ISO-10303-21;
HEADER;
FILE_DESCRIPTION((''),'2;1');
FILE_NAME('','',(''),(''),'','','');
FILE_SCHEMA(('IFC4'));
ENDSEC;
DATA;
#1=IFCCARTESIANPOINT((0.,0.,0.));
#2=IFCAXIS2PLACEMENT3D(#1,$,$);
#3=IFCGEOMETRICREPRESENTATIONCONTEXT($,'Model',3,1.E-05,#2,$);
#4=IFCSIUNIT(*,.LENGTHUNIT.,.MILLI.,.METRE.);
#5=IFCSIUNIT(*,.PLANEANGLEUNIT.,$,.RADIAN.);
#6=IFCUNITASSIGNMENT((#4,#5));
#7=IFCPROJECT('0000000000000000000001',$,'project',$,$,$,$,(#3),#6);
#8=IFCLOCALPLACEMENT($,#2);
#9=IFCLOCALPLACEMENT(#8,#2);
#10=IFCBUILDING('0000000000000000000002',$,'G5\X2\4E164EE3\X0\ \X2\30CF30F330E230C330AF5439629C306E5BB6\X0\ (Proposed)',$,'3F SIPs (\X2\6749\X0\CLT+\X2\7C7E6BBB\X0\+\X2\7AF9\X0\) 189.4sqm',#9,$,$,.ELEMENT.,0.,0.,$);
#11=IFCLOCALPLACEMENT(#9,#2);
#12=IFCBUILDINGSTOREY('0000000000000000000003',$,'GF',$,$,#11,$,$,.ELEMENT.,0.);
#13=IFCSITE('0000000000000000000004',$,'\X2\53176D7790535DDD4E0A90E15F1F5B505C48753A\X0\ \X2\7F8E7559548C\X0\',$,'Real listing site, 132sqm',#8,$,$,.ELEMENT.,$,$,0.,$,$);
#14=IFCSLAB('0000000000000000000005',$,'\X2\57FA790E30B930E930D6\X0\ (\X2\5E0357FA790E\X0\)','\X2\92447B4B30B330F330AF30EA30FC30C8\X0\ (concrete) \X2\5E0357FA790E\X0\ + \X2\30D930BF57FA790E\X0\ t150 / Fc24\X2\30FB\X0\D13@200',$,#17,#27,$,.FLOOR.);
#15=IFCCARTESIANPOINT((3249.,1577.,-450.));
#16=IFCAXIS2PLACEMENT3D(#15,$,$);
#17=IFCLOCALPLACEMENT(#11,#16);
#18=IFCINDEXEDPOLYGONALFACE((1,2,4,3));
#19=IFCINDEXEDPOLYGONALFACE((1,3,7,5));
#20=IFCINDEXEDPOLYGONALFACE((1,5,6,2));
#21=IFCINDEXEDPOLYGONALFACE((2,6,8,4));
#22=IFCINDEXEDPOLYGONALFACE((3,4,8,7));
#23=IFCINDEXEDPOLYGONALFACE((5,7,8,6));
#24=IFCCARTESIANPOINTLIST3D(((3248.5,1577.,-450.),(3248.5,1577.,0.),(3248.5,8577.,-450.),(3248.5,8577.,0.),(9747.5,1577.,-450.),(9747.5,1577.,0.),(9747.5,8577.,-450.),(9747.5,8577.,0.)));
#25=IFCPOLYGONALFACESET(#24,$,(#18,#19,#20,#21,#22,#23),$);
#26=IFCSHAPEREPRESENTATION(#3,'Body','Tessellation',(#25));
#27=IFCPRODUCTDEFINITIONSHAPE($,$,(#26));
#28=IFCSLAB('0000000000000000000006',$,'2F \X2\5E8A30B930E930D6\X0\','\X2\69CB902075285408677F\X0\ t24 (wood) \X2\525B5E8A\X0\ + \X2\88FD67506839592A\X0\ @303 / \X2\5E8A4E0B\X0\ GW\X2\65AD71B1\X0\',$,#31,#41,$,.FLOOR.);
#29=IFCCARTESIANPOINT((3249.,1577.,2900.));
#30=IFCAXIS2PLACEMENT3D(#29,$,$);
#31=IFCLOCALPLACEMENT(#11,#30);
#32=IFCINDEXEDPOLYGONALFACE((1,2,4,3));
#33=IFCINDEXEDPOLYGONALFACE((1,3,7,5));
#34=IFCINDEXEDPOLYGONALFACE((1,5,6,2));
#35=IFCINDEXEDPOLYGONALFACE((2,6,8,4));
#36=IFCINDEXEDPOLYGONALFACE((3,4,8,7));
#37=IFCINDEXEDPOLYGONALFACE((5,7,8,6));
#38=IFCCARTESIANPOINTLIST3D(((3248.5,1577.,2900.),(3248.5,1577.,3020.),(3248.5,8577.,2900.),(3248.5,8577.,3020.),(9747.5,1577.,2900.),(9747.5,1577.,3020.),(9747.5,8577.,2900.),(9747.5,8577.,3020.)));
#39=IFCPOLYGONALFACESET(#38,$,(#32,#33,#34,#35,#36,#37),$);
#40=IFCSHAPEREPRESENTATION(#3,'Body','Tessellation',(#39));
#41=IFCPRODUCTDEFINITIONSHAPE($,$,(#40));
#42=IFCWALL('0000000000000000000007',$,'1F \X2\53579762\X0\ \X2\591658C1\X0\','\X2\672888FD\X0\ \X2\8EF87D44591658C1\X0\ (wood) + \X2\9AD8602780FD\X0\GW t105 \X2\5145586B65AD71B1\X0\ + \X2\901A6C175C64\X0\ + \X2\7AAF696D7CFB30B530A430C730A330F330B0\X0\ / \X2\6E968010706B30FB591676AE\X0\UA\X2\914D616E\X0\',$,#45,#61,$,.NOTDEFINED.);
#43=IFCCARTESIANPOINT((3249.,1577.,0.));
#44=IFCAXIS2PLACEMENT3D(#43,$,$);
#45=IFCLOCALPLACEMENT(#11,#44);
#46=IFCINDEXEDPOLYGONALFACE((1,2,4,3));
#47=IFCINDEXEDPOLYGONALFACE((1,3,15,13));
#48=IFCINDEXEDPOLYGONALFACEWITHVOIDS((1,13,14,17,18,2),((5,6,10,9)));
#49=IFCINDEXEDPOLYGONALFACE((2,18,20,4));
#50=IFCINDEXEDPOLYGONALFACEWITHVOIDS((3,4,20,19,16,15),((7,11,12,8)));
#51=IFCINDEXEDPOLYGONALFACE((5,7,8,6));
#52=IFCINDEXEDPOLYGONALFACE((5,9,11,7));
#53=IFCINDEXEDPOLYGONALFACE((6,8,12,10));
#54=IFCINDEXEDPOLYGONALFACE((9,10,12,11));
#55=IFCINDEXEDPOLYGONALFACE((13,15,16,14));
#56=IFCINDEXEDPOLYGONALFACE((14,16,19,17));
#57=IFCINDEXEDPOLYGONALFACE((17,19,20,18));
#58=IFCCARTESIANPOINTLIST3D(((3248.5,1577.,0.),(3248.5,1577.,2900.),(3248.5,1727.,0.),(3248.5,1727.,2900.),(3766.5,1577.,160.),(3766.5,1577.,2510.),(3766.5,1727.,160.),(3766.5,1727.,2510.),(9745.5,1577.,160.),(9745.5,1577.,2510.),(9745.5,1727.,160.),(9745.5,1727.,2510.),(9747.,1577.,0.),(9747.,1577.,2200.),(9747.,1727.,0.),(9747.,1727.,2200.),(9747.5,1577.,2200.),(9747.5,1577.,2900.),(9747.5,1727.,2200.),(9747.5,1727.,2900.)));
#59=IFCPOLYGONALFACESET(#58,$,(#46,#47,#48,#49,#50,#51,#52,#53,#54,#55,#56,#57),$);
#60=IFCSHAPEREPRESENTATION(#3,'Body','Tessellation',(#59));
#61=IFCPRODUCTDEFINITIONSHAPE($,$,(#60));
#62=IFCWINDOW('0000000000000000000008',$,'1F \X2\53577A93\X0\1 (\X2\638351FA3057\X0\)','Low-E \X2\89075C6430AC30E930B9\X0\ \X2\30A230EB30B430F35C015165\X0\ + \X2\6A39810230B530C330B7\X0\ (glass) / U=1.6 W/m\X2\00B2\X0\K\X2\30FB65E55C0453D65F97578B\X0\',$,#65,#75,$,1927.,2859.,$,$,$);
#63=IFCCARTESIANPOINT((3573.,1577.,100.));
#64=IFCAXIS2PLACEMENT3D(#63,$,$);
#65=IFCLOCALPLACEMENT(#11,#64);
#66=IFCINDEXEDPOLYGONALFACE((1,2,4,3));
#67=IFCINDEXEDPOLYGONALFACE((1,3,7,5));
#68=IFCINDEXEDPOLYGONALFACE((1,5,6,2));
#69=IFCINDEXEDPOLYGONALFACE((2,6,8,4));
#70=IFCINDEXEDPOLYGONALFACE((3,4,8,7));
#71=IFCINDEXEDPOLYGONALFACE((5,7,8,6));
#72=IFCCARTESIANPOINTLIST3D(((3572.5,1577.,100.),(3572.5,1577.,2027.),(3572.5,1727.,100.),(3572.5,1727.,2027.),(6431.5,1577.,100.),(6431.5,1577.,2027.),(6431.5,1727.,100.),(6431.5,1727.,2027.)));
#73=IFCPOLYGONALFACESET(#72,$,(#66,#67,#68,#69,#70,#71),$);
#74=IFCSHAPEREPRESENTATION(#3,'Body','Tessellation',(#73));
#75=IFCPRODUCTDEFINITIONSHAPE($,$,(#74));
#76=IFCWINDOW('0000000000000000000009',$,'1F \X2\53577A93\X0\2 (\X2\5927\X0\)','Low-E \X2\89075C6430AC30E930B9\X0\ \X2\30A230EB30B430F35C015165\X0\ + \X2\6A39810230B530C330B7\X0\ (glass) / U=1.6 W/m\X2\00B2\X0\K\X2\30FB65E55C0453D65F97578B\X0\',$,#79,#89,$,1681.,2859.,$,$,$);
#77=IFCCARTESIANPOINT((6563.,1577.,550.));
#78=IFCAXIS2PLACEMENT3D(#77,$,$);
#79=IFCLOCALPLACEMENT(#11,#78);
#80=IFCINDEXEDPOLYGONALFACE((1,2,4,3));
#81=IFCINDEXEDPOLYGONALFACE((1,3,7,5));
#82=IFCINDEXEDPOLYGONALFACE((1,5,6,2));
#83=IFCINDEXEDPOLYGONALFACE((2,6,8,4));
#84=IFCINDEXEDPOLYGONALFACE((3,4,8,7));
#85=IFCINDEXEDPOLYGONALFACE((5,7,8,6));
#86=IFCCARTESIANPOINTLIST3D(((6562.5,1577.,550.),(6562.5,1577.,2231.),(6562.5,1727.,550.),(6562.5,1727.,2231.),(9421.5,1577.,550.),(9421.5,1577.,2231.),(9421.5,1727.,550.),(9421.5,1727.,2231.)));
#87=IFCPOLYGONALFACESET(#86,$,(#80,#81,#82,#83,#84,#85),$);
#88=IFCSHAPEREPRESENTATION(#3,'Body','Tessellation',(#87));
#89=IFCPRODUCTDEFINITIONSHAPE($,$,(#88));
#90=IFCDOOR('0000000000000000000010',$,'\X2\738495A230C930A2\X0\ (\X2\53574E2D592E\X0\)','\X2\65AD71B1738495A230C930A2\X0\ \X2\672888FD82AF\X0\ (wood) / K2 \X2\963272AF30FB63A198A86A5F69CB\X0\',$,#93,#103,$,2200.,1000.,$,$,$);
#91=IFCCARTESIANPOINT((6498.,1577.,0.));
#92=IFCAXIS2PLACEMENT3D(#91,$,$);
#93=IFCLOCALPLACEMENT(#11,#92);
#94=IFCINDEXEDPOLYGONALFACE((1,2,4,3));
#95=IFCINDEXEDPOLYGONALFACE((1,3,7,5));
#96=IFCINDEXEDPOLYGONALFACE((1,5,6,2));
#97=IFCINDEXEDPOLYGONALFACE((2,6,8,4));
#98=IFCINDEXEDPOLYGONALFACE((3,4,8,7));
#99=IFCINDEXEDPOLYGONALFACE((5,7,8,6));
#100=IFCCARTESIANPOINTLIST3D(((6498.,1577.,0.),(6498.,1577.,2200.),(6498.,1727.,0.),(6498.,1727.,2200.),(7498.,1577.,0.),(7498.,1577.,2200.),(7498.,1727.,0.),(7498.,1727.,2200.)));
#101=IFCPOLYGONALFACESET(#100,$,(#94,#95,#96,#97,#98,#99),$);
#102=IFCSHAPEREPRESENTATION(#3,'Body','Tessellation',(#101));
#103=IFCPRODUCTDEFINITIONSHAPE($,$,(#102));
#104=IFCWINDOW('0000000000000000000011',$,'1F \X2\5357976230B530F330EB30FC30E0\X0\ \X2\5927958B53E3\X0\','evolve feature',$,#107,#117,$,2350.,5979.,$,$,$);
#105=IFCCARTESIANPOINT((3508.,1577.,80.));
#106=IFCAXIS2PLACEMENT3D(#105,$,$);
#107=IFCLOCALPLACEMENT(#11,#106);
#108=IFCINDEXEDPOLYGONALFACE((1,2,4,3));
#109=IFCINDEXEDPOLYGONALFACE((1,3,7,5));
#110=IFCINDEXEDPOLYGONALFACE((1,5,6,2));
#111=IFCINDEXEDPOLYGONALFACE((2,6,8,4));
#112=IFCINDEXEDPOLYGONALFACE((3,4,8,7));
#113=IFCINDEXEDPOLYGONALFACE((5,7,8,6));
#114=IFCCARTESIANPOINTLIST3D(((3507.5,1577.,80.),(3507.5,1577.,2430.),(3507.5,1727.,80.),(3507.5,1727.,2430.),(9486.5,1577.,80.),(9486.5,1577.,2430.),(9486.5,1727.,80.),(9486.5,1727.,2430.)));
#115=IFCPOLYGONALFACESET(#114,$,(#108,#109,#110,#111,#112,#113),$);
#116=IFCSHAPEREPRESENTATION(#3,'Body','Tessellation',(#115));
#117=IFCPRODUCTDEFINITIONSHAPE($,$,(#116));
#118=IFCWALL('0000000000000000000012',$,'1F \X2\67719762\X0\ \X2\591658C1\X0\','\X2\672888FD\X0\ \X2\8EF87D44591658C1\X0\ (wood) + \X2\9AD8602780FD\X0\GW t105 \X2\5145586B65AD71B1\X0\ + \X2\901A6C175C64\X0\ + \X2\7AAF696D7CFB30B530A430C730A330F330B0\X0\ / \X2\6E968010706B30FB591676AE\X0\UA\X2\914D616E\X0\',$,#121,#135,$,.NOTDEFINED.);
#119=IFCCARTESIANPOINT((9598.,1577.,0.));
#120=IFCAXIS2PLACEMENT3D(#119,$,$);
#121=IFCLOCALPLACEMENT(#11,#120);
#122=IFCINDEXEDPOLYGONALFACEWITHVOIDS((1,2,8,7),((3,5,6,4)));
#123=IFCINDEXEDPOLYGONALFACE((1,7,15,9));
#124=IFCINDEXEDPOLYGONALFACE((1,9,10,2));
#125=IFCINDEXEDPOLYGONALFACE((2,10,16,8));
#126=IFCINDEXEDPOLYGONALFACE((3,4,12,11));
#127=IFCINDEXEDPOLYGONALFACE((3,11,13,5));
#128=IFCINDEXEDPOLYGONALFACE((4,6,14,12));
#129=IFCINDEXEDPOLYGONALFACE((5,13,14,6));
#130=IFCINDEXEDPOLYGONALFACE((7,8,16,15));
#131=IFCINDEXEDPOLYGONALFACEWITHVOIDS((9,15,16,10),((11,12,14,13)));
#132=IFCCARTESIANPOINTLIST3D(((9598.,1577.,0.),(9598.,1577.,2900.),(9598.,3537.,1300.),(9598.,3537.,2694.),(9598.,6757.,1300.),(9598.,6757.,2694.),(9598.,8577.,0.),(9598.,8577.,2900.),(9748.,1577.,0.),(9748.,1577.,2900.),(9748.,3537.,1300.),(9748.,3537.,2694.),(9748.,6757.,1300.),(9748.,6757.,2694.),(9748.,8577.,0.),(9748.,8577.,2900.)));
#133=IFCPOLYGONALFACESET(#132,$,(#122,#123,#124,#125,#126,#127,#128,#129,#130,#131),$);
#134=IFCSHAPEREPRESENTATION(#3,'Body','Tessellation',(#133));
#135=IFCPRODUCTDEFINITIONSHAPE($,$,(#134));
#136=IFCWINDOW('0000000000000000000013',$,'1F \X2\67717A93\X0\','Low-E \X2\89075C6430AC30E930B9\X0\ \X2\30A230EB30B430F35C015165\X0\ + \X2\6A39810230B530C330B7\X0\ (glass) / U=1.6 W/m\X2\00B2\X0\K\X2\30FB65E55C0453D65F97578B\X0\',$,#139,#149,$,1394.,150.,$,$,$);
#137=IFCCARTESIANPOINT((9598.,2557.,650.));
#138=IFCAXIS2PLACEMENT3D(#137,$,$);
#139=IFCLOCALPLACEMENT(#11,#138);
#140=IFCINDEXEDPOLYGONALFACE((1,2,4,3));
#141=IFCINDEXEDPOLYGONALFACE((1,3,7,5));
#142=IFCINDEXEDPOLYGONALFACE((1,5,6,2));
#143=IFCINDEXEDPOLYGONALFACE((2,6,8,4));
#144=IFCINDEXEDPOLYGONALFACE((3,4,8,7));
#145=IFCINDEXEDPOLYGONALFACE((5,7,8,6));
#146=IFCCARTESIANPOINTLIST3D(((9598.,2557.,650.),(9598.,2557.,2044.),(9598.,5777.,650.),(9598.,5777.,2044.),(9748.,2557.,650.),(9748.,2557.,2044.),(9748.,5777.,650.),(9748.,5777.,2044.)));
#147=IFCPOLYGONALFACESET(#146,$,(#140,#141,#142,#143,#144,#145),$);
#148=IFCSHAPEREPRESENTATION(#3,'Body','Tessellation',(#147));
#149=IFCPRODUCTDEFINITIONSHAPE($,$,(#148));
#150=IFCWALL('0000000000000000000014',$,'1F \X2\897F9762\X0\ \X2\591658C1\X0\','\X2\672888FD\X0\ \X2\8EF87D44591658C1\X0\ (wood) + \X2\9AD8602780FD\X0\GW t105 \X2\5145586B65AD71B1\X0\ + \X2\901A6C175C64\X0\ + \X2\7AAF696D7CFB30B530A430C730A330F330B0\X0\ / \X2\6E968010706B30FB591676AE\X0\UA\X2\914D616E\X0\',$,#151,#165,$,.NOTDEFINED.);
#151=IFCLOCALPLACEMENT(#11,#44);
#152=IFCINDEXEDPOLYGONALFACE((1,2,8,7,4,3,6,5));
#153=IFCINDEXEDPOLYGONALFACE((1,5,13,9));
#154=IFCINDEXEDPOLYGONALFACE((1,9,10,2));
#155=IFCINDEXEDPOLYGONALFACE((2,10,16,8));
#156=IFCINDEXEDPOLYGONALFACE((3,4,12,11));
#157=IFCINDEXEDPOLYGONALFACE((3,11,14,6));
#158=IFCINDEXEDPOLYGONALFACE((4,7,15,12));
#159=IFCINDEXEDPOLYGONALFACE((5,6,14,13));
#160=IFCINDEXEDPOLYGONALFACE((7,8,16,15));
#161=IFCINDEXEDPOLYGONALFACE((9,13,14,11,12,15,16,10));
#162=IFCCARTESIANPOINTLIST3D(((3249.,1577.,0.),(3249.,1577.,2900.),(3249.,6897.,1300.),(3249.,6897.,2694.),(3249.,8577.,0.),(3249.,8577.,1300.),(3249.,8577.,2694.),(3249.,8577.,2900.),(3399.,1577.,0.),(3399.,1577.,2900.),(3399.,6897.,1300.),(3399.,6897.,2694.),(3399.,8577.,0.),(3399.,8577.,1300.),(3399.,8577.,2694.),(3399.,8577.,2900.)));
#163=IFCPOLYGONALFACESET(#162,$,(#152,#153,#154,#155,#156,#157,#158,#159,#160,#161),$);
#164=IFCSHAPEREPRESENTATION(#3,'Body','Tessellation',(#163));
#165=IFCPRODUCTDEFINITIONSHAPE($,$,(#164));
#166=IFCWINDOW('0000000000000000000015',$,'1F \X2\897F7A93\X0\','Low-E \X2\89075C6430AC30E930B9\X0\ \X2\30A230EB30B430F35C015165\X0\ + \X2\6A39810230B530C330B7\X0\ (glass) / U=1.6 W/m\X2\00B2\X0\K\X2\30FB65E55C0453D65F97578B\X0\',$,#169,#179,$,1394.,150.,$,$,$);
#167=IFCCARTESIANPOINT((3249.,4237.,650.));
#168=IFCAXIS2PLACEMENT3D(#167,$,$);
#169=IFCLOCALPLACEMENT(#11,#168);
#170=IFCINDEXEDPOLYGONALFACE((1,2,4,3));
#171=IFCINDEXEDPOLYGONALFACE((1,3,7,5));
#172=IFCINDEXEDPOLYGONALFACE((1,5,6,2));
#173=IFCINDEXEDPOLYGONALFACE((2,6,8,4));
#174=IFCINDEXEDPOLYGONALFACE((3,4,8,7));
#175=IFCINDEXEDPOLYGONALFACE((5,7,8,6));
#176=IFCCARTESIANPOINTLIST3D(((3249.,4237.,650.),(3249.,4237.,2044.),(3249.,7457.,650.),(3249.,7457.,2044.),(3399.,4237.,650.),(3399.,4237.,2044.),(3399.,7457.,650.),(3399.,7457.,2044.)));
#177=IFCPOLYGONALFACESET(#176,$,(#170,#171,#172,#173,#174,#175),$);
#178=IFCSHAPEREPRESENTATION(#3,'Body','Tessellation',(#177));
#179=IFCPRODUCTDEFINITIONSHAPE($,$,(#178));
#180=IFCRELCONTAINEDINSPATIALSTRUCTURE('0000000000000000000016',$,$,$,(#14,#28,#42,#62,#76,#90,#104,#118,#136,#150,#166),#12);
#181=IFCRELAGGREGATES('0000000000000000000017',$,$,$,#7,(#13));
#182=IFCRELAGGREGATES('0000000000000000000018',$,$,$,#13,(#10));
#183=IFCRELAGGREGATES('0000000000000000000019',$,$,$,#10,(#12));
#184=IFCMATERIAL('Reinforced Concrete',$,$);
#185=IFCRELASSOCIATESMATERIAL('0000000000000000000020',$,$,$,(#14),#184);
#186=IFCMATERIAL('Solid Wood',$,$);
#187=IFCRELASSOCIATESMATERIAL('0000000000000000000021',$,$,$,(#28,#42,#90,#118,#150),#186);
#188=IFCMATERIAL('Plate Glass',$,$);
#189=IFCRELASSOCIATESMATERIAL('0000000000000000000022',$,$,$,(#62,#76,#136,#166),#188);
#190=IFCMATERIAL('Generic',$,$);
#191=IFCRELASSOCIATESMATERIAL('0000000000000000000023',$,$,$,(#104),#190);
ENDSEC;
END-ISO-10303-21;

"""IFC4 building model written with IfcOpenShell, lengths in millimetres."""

from ifc_helpers import new_model, si_unit, frame, frame_2d, origin, place, context, project, spatial, rectangle, extrude, material, element, fill, save


model = new_model("IFC4")

# Units and contexts
model_context = context("Model", 3, precision=1e-05, world=origin())
ifc_project = project(units=[si_unit("LENGTHUNIT", "METRE", prefix="MILLI"), si_unit("PLANEANGLEUNIT", "RADIAN")], contexts=[model_context])

# Site, building, storey
site_placement = place(None, origin())
site = spatial("IfcSite", under=ifc_project, at=site_placement, Name="北海道川上郡弟子屈町 美留和", ObjectType="Real listing site, 132sqm", CompositionType="ELEMENT", RefElevation=0.0)
building_placement = place(site_placement, origin())
building = spatial("IfcBuilding", under=site, at=building_placement, Name="G5世代 ハンモック吹抜の家 (Proposed)", ObjectType="3F SIPs (杉CLT+籾殻+竹) 189.4sqm", CompositionType="ELEMENT", ElevationOfRefHeight=0.0, ElevationOfTerrain=0.0)
storey_placement = place(building_placement, origin())
storey = spatial("IfcBuildingStorey", under=building, at=storey_placement, Name="GF", CompositionType="ELEMENT", Elevation=0.0)

# Slabs
ifc_material_1 = material(Name="Reinforced Concrete")
slab_1_placement = place(storey_placement, frame((3249.0, 1577.0, -450.0)))
element("IfcSlab", 1, at=slab_1_placement, inside=storey, material=ifc_material_1, Name="基礎スラブ (布基礎)", Description="鉄筋コンクリート (concrete) 布基礎 + ベタ基礎 t150 / Fc24・D13@200", PredefinedType="FLOOR", context=model_context, shape_type="SweptSolid", body=[
    extrude(rectangle(XDim=6499.0, YDim=7000.0, at=frame_2d((3249.0, 3500.0))), frame((3249.0, 1577.0, -450.0)), (0.0, 0.0, 1.0), 450.0),
])
ifc_material_2 = material(Name="Solid Wood")
slab_2_placement = place(storey_placement, frame((3249.0, 1577.0, 2900.0)))
element("IfcSlab", 2, at=slab_2_placement, inside=storey, material=ifc_material_2, Name="2F 床スラブ", Description="構造用合板 t24 (wood) 剛床 + 製材根太 @303 / 床下 GW断熱", PredefinedType="FLOOR", context=model_context, shape_type="SweptSolid", body=[
    extrude(rectangle(XDim=6499.0, YDim=7000.0, at=frame_2d((3249.0, 3500.0))), frame((3249.0, 1577.0, 2900.0)), (0.0, 0.0, 1.0), 120.0),
])

# Wall, openings, windows, door
wall_1_placement = place(storey_placement, frame((3249.0, 1577.0, 0.0)))
wall_1 = element("IfcWall", 3, at=wall_1_placement, inside=storey, material=ifc_material_2, Name="1F 南面 外壁", Description="木製 軸組外壁 (wood) + 高性能GW t105 充填断熱 + 通気層 + 窯業系サイディング / 準耐火・外皮UA配慮", PredefinedType="NOTDEFINED", context=model_context, shape_type="SweptSolid", body=[
    extrude(rectangle(XDim=6499.0, YDim=150.0, at=frame_2d((3249.0, 75.0))), frame((3249.0, 1577.0, 0.0)), (0.0, 0.0, 1.0), 2900.0),
])
opening_1_placement = place(storey_placement, frame((3573.0, 1577.0, 100.0)))
opening_1 = element("IfcOpeningElement", 4, at=opening_1_placement, cuts=wall_1, PredefinedType="NOTDEFINED", context=model_context, shape_type="SweptSolid", body=[
    extrude(rectangle(XDim=2859.0, YDim=150.0, at=frame_2d((1429.0, 75.0))), frame((3573.0, 1577.0, 100.0)), (0.0, 0.0, 1.0), 1927.0),
])
opening_2_placement = place(storey_placement, frame((6563.0, 1577.0, 550.0)))
opening_2 = element("IfcOpeningElement", 5, at=opening_2_placement, cuts=wall_1, PredefinedType="NOTDEFINED", context=model_context, shape_type="SweptSolid", body=[
    extrude(rectangle(XDim=2859.0, YDim=150.0, at=frame_2d((1429.0, 75.0))), frame((6563.0, 1577.0, 550.0)), (0.0, 0.0, 1.0), 1681.0),
])
opening_3_placement = place(storey_placement, frame((6498.0, 1577.0, 0.0)))
opening_3 = element("IfcOpeningElement", 6, at=opening_3_placement, cuts=wall_1, PredefinedType="NOTDEFINED", context=model_context, shape_type="SweptSolid", body=[
    extrude(rectangle(XDim=1000.0, YDim=150.0, at=frame_2d((500.0, 75.0))), frame((6498.0, 1577.0, 0.0)), (0.0, 0.0, 1.0), 2200.0),
])
opening_4_placement = place(storey_placement, frame((3508.0, 1577.0, 80.0)))
opening_4 = element("IfcOpeningElement", 7, at=opening_4_placement, cuts=wall_1, PredefinedType="NOTDEFINED", context=model_context, shape_type="SweptSolid", body=[
    extrude(rectangle(XDim=5979.0, YDim=150.0, at=frame_2d((2989.0, 75.0))), frame((3508.0, 1577.0, 80.0)), (0.0, 0.0, 1.0), 2350.0),
])
ifc_material_3 = material(Name="Plate Glass")
window_1_placement = place(storey_placement, frame((3573.0, 1577.0, 100.0)))
window_1 = element("IfcWindow", 8, at=window_1_placement, inside=storey, material=ifc_material_3, Name="1F 南窓1 (掃出し)", Description="Low-E 複層ガラス アルゴン封入 + 樹脂サッシ (glass) / U=1.6 W/m²K・日射取得型", OverallHeight=1927.0, OverallWidth=2859.0, context=model_context, shape_type="SweptSolid", body=[
    extrude(rectangle(XDim=2859.0, YDim=150.0, at=frame_2d((1429.0, 75.0))), frame((3573.0, 1577.0, 100.0)), (0.0, 0.0, 1.0), 1927.0),
])
fill(opening_1, window_1)
window_2_placement = place(storey_placement, frame((6563.0, 1577.0, 550.0)))
window_2 = element("IfcWindow", 9, at=window_2_placement, inside=storey, material=ifc_material_3, Name="1F 南窓2 (大)", Description="Low-E 複層ガラス アルゴン封入 + 樹脂サッシ (glass) / U=1.6 W/m²K・日射取得型", OverallHeight=1681.0, OverallWidth=2859.0, context=model_context, shape_type="SweptSolid", body=[
    extrude(rectangle(XDim=2859.0, YDim=150.0, at=frame_2d((1429.0, 75.0))), frame((6563.0, 1577.0, 550.0)), (0.0, 0.0, 1.0), 1681.0),
])
fill(opening_2, window_2)
door_placement = place(storey_placement, frame((6498.0, 1577.0, 0.0)))
door = element("IfcDoor", 10, at=door_placement, inside=storey, material=ifc_material_2, Name="玄関ドア (南中央)", Description="断熱玄関ドア 木製芯 (wood) / K2 防犯・採風機構", OverallHeight=2200.0, OverallWidth=1000.0, context=model_context, shape_type="SweptSolid", body=[
    extrude(rectangle(XDim=1000.0, YDim=150.0, at=frame_2d((500.0, 75.0))), frame((6498.0, 1577.0, 0.0)), (0.0, 0.0, 1.0), 2200.0),
])
fill(opening_3, door)
ifc_material_4 = material(Name="Generic")
window_3_placement = place(storey_placement, frame((3508.0, 1577.0, 80.0)))
window_3 = element("IfcWindow", 11, at=window_3_placement, inside=storey, material=ifc_material_4, Name="1F 南面サンルーム 大開口", Description="evolve feature", OverallHeight=2350.0, OverallWidth=5979.0, context=model_context, shape_type="SweptSolid", body=[
    extrude(rectangle(XDim=5979.0, YDim=150.0, at=frame_2d((2989.0, 75.0))), frame((3508.0, 1577.0, 80.0)), (0.0, 0.0, 1.0), 2350.0),
])
fill(opening_4, window_3)

# Walls, openings, windows
wall_2_placement = place(storey_placement, frame((9598.0, 1577.0, 0.0)))
wall_2 = element("IfcWall", 12, at=wall_2_placement, inside=storey, material=ifc_material_2, Name="1F 東面 外壁", Description="木製 軸組外壁 (wood) + 高性能GW t105 充填断熱 + 通気層 + 窯業系サイディング / 準耐火・外皮UA配慮", PredefinedType="NOTDEFINED", context=model_context, shape_type="SweptSolid", body=[
    extrude(rectangle(XDim=150.0, YDim=7000.0, at=frame_2d((75.0, 3500.0))), frame((9598.0, 1577.0, 0.0)), (0.0, 0.0, 1.0), 2900.0),
])
opening_5_placement = place(storey_placement, frame((9598.0, 2557.0, 650.0)))
opening_5 = element("IfcOpeningElement", 13, at=opening_5_placement, cuts=wall_2, PredefinedType="NOTDEFINED", context=model_context, shape_type="SweptSolid", body=[
    extrude(rectangle(XDim=150.0, YDim=3220.0, at=frame_2d((75.0, 1610.0))), frame((9598.0, 2557.0, 650.0)), (0.0, 0.0, 1.0), 1394.0),
])
window_4_placement = place(storey_placement, frame((9598.0, 2557.0, 650.0)))
window_4 = element("IfcWindow", 14, at=window_4_placement, inside=storey, material=ifc_material_3, Name="1F 東窓", Description="Low-E 複層ガラス アルゴン封入 + 樹脂サッシ (glass) / U=1.6 W/m²K・日射取得型", OverallHeight=1394.0, OverallWidth=150.0, context=model_context, shape_type="SweptSolid", body=[
    extrude(rectangle(XDim=150.0, YDim=3220.0, at=frame_2d((75.0, 1610.0))), frame((9598.0, 2557.0, 650.0)), (0.0, 0.0, 1.0), 1394.0),
])
fill(opening_5, window_4)
wall_3_placement = place(storey_placement, frame((3249.0, 1577.0, 0.0)))
wall_3 = element("IfcWall", 15, at=wall_3_placement, inside=storey, material=ifc_material_2, Name="1F 西面 外壁", Description="木製 軸組外壁 (wood) + 高性能GW t105 充填断熱 + 通気層 + 窯業系サイディング / 準耐火・外皮UA配慮", PredefinedType="NOTDEFINED", context=model_context, shape_type="SweptSolid", body=[
    extrude(rectangle(XDim=150.0, YDim=7000.0, at=frame_2d((75.0, 3500.0))), frame((3249.0, 1577.0, 0.0)), (0.0, 0.0, 1.0), 2900.0),
])
opening_6_placement = place(storey_placement, frame((3249.0, 4237.0, 650.0)))
opening_6 = element("IfcOpeningElement", 16, at=opening_6_placement, cuts=wall_3, PredefinedType="NOTDEFINED", context=model_context, shape_type="SweptSolid", body=[
    extrude(rectangle(XDim=150.0, YDim=3220.0, at=frame_2d((75.0, 1610.0))), frame((3249.0, 4237.0, 650.0)), (0.0, 0.0, 1.0), 1394.0),
])
window_5_placement = place(storey_placement, frame((3249.0, 4237.0, 650.0)))
window_5 = element("IfcWindow", 17, at=window_5_placement, inside=storey, material=ifc_material_3, Name="1F 西窓", Description="Low-E 複層ガラス アルゴン封入 + 樹脂サッシ (glass) / U=1.6 W/m²K・日射取得型", OverallHeight=1394.0, OverallWidth=150.0, context=model_context, shape_type="SweptSolid", body=[
    extrude(rectangle(XDim=150.0, YDim=3220.0, at=frame_2d((75.0, 1610.0))), frame((3249.0, 4237.0, 650.0)), (0.0, 0.0, 1.0), 1394.0),
])
fill(opening_6, window_5)

save(model, "model.ifc")
